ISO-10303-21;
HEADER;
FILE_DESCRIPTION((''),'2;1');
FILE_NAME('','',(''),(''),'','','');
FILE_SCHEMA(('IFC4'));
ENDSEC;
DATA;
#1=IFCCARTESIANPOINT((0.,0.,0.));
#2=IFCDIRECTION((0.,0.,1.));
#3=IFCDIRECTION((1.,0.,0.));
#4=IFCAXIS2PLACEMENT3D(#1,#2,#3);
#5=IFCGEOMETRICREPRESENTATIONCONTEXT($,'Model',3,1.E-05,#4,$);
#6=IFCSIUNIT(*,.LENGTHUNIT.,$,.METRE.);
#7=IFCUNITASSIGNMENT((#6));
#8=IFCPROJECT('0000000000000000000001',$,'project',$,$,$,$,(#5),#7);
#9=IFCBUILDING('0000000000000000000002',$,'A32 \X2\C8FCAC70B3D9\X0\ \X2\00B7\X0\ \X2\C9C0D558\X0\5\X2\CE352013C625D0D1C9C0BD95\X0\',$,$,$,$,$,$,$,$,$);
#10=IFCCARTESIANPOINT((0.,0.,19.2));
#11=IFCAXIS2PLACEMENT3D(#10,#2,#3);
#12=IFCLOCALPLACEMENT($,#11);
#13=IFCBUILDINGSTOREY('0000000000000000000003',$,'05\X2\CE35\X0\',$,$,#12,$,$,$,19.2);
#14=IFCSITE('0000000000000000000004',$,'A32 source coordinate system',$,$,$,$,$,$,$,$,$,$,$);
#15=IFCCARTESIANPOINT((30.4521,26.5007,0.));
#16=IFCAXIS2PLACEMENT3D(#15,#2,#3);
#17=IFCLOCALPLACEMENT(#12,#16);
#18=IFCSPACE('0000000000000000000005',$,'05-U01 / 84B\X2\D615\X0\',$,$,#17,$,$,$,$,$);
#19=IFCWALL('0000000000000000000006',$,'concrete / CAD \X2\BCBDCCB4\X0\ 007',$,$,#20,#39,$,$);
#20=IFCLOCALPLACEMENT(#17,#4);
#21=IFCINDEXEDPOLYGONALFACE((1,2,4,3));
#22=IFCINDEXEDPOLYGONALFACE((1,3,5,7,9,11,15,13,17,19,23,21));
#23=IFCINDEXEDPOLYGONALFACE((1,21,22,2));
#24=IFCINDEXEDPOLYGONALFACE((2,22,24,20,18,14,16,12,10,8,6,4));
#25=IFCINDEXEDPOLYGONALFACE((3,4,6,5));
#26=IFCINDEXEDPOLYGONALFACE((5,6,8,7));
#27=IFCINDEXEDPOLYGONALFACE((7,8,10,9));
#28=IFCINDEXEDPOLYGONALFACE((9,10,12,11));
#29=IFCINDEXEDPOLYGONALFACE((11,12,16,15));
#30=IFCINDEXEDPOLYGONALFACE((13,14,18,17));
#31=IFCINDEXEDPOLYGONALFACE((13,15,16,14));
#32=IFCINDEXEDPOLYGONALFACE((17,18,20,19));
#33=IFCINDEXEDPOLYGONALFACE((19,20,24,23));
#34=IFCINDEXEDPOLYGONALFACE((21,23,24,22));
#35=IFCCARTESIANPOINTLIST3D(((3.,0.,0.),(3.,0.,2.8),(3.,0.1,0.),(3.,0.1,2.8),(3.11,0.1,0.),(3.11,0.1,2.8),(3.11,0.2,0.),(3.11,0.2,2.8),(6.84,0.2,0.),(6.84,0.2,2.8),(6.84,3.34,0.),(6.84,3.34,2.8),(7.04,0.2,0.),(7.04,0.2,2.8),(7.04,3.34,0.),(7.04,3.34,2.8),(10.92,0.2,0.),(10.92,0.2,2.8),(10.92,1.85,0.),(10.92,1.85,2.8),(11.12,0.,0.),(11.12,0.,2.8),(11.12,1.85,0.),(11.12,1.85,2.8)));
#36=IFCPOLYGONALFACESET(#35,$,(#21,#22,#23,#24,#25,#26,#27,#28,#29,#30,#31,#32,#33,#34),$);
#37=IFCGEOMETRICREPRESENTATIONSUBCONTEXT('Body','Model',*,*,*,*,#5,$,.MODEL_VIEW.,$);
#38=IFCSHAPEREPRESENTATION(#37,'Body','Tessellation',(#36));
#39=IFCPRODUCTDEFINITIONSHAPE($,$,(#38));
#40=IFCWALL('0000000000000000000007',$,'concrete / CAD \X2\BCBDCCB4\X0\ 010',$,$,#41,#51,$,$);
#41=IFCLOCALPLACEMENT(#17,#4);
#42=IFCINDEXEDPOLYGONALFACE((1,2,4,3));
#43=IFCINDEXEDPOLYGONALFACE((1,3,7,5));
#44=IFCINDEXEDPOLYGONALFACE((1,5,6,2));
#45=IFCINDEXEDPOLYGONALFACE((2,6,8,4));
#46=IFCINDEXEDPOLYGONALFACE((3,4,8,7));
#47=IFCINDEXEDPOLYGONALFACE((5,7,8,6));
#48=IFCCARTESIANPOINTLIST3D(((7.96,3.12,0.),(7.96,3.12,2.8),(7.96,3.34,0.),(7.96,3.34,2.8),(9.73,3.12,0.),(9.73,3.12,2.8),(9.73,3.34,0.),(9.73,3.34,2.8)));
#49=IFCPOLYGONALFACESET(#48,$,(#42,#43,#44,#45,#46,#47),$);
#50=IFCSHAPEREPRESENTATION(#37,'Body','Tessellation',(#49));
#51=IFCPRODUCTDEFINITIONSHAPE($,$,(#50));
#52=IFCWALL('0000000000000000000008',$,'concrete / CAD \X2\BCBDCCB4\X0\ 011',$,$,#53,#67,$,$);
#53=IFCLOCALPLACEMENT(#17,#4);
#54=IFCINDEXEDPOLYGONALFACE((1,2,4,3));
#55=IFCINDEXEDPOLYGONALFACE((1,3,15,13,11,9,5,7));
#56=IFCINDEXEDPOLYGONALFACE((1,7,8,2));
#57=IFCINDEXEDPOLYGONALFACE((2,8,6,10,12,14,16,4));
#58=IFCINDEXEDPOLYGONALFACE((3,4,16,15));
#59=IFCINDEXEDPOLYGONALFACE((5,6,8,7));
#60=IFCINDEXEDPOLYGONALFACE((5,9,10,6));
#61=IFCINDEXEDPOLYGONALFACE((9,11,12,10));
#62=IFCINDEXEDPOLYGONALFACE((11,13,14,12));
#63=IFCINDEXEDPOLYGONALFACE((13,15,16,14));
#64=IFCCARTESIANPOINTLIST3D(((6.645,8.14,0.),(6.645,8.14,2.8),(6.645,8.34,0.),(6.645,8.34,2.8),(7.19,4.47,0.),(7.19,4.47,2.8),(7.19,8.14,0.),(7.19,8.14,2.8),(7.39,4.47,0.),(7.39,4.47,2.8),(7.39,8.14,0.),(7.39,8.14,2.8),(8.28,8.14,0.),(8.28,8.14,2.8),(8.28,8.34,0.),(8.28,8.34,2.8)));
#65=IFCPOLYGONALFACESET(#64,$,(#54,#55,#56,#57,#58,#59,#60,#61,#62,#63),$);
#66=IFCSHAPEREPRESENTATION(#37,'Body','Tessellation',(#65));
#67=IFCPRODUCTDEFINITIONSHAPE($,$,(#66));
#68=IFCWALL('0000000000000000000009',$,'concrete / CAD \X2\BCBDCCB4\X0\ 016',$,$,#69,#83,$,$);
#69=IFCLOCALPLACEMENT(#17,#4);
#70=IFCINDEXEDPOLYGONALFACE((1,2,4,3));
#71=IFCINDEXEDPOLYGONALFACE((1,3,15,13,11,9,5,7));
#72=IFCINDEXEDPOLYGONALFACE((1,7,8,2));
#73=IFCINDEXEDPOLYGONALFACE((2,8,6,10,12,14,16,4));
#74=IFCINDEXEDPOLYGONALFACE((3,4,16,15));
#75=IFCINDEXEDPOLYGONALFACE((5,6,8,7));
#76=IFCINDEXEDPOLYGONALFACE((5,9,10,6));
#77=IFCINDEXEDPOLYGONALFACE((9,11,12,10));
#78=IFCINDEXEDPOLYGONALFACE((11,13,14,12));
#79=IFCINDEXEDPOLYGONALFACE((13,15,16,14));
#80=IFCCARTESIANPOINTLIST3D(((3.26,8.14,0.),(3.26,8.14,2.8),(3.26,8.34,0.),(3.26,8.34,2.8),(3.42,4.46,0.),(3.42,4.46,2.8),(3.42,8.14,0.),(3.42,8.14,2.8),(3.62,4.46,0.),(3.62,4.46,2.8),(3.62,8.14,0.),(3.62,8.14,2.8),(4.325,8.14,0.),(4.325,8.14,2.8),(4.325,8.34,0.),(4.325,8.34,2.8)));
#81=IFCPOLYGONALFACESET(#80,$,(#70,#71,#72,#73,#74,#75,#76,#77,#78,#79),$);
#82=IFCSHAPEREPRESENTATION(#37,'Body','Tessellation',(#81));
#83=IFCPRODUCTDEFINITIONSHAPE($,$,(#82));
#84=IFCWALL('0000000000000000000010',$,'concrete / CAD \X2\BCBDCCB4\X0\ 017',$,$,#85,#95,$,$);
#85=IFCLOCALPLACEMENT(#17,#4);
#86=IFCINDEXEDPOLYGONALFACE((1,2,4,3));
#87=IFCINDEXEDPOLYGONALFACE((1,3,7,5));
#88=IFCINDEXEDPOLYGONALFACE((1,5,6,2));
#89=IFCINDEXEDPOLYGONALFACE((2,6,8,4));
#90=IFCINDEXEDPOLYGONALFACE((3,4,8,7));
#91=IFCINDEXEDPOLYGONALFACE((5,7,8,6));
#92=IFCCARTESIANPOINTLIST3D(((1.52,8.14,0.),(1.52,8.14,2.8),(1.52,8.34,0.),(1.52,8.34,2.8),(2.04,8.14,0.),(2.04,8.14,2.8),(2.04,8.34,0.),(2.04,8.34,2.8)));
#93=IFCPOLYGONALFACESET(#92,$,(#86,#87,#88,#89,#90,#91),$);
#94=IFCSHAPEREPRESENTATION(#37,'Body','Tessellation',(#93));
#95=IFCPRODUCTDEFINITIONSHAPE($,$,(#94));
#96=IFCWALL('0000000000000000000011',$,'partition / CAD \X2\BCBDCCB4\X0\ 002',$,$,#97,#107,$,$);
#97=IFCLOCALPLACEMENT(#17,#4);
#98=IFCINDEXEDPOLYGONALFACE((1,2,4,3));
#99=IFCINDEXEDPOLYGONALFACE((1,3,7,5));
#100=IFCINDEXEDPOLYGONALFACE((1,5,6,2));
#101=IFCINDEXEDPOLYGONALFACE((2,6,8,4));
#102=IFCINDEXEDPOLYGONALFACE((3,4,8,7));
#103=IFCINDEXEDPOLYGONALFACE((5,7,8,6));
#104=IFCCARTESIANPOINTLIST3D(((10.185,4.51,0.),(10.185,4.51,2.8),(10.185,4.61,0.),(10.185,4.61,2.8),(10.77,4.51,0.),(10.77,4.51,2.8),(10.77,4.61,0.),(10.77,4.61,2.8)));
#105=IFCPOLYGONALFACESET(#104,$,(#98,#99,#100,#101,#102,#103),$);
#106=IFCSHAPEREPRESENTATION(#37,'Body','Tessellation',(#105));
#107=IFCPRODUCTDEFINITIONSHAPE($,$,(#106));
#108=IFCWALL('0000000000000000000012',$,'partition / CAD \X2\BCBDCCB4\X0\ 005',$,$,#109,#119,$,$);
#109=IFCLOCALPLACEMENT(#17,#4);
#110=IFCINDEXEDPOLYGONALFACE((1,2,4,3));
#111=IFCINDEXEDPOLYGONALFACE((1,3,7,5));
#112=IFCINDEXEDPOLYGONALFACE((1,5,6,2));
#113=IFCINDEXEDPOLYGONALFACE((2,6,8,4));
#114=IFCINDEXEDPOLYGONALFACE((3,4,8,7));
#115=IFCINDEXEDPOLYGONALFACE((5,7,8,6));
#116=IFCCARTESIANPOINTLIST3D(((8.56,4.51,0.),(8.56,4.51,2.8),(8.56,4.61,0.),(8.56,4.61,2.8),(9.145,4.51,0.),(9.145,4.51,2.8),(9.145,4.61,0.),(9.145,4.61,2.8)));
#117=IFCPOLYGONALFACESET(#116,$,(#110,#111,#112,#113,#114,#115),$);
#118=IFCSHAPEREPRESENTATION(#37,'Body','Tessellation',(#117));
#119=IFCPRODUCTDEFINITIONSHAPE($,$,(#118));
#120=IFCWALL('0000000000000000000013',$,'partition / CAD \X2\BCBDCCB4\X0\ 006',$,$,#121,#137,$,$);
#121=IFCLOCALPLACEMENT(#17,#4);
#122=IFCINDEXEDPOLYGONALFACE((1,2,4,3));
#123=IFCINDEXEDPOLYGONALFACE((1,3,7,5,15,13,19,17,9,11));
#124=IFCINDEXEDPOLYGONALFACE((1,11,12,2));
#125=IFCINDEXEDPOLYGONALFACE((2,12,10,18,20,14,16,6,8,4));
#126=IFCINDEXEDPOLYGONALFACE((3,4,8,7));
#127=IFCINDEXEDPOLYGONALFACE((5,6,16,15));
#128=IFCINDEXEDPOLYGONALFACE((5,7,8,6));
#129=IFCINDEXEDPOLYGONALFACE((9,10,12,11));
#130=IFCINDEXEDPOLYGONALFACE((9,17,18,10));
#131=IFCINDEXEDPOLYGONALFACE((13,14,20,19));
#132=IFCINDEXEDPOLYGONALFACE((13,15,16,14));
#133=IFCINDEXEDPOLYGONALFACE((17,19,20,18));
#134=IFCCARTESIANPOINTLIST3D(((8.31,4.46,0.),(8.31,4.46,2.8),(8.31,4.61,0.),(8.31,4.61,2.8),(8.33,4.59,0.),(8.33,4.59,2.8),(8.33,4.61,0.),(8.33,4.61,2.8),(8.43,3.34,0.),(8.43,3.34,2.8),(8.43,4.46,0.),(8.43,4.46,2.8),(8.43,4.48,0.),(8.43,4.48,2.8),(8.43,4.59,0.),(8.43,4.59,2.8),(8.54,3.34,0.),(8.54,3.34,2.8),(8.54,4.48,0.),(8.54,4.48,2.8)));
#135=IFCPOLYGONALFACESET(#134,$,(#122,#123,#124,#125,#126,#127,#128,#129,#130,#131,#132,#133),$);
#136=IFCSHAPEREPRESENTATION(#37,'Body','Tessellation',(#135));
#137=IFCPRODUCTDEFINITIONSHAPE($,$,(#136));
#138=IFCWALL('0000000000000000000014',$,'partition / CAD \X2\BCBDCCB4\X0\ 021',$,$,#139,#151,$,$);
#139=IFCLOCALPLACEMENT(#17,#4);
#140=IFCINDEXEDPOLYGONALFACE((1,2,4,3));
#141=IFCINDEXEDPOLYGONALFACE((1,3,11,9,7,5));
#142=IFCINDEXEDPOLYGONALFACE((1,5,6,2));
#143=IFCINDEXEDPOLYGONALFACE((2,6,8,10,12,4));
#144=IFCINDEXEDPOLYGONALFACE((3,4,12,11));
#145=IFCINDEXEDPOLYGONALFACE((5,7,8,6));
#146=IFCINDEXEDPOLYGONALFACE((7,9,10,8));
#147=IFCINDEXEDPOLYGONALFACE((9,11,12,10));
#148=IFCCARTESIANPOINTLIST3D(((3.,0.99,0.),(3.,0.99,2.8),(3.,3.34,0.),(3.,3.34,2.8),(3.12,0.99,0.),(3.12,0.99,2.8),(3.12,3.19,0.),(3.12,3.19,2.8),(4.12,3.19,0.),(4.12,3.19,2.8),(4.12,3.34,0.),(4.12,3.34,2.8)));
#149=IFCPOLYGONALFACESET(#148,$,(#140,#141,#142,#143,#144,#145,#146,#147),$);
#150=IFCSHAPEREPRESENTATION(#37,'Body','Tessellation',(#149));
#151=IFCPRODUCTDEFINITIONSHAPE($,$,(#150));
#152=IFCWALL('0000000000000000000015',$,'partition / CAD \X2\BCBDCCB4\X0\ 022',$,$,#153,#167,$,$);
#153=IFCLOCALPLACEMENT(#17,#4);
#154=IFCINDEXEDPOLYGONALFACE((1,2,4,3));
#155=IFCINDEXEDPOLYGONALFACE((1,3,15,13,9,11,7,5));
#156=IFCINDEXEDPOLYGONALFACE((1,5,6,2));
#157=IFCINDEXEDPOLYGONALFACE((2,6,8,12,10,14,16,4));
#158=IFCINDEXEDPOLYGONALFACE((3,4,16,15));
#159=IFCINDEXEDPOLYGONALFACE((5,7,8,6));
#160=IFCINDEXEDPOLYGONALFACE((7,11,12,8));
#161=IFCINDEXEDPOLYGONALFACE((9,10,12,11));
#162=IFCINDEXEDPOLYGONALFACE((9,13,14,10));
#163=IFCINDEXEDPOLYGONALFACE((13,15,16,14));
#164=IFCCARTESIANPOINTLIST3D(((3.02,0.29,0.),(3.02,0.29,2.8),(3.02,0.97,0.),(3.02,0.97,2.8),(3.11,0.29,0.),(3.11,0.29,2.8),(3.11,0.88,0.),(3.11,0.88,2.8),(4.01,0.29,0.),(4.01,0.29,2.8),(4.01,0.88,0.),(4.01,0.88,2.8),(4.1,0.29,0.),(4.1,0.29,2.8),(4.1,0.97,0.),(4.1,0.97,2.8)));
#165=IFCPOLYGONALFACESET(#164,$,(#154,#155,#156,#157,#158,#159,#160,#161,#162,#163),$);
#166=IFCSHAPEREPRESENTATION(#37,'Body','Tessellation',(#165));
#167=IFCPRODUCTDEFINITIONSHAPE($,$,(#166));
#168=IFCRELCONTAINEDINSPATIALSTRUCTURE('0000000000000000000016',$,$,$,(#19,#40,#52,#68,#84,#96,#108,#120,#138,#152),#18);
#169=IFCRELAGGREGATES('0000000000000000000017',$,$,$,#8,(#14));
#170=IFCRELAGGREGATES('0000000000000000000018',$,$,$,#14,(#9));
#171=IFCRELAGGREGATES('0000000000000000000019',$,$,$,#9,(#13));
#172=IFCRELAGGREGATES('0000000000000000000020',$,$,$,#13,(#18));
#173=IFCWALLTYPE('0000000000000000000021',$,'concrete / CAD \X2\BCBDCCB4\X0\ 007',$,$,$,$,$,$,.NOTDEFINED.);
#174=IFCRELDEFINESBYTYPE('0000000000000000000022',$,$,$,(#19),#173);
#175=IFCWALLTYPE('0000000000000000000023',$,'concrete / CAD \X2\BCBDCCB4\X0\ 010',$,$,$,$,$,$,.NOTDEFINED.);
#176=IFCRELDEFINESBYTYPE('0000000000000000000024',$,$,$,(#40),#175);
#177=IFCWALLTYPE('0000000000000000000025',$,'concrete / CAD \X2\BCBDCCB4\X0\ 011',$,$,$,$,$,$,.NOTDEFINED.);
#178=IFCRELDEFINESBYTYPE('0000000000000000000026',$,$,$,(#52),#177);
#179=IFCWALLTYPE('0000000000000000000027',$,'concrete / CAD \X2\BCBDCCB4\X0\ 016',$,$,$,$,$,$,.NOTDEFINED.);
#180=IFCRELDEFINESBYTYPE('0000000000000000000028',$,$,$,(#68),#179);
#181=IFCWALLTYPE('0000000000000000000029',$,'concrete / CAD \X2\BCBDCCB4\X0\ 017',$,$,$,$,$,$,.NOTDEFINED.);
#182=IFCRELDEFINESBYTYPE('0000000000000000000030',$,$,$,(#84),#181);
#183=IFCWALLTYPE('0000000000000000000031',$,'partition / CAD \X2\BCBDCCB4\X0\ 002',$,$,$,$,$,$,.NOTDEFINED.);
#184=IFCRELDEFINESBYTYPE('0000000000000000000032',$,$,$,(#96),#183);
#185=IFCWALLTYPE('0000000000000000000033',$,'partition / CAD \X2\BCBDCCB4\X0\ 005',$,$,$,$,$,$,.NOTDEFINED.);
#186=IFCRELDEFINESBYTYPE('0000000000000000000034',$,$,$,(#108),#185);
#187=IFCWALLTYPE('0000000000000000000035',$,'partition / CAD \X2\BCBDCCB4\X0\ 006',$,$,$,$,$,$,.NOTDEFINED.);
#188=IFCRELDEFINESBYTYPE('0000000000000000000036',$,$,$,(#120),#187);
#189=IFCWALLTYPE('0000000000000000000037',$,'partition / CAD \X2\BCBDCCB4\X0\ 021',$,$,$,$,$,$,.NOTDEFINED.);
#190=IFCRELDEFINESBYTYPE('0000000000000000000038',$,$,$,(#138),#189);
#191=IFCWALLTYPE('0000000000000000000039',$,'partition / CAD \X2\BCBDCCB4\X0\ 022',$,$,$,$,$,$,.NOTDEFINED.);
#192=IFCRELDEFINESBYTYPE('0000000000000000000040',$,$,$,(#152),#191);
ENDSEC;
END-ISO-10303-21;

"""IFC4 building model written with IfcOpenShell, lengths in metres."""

from ifc_helpers import new_model, si_unit, frame, origin, origin_with_axes, place, context, subcontext, project, spatial, polyline, outline, extrude, source, transform, mapped, type_object, type_shapes, element, save


model = new_model("IFC4")

# Units and contexts
model_context = context("Model", 3, precision=1e-05, world=origin_with_axes())
body_context = subcontext(model_context, "Body", "Model", "MODEL_VIEW")
ifc_project = project(units=[si_unit("LENGTHUNIT", "METRE")], contexts=[model_context])

# Site, building, storey, space
site = spatial("IfcSite", under=ifc_project, Name="A32 source coordinate system")
building = spatial("IfcBuilding", under=site, Name="A32 주거동 · 지하5층–옥탑지붕")
storey_placement = place(None, frame((0.0, 0.0, 19.2), z_axis=(0.0, 0.0, 1.0), x_axis=(1.0, 0.0, 0.0)))
storey = spatial("IfcBuildingStorey", under=building, at=storey_placement, Name="05층", Elevation=19.2)
space_1_placement = place(storey_placement, frame((30.4521, 26.5007, 0.0), z_axis=(0.0, 0.0, 1.0), x_axis=(1.0, 0.0, 0.0)))
space_1 = spatial("IfcSpace", under=storey, at=space_1_placement, Name="05-U01 / 84B형")

# Walls
wall_type_1 = type_object("IfcWallType", Name="concrete / CAD 벽체 007", PredefinedType="NOTDEFINED")
shared_shape_1 = source(origin(), body_context, "Body", "SweptSolid", [
    extrude(outline(polyline([(3.0, 0.0), (3.0, 0.1), (3.11, 0.1), (3.11, 0.2), (6.84, 0.2), (6.84, 3.34), (7.04, 3.34), (7.04, 0.2), (10.92, 0.2), (10.92, 1.85), (11.12, 1.85), (11.12, 0.0), (3.0, 0.0)])), origin(), (0.0, 0.0, 1.0), 2.8),
])
type_shapes(wall_type_1, [shared_shape_1])
wall_1_placement = place(space_1_placement, origin_with_axes())
element("IfcWall", 1, at=wall_1_placement, inside=space_1, type_object=wall_type_1, Name="concrete / CAD 벽체 007", context=body_context, shape_type="MappedRepresentation", body=[
    mapped(shared_shape_1, transform((0.0, 0.0, 0.0), scale=1.0)),
])
wall_type_2 = type_object("IfcWallType", Name="concrete / CAD 벽체 010", PredefinedType="NOTDEFINED")
shared_shape_2 = source(origin(), body_context, "Body", "SweptSolid", [
    extrude(outline(polyline([(7.96, 3.12), (7.96, 3.34), (9.73, 3.34), (9.73, 3.12), (7.96, 3.12)])), origin(), (0.0, 0.0, 1.0), 2.8),
])
type_shapes(wall_type_2, [shared_shape_2])
wall_2_placement = place(space_1_placement, origin_with_axes())
element("IfcWall", 2, at=wall_2_placement, inside=space_1, type_object=wall_type_2, Name="concrete / CAD 벽체 010", context=body_context, shape_type="MappedRepresentation", body=[
    mapped(shared_shape_2, transform((0.0, 0.0, 0.0), scale=1.0)),
])
wall_type_3 = type_object("IfcWallType", Name="concrete / CAD 벽체 011", PredefinedType="NOTDEFINED")
shared_shape_3 = source(origin(), body_context, "Body", "SweptSolid", [
    extrude(outline(polyline([(7.19, 8.14), (6.645, 8.14), (6.645, 8.34), (8.28, 8.34), (8.28, 8.14), (7.39, 8.14), (7.39, 4.47), (7.19, 4.47), (7.19, 8.14)])), origin(), (0.0, 0.0, 1.0), 2.8),
])
type_shapes(wall_type_3, [shared_shape_3])
wall_3_placement = place(space_1_placement, origin_with_axes())
element("IfcWall", 3, at=wall_3_placement, inside=space_1, type_object=wall_type_3, Name="concrete / CAD 벽체 011", context=body_context, shape_type="MappedRepresentation", body=[
    mapped(shared_shape_3, transform((0.0, 0.0, 0.0), scale=1.0)),
])
wall_type_4 = type_object("IfcWallType", Name="concrete / CAD 벽체 016", PredefinedType="NOTDEFINED")
shared_shape_4 = source(origin(), body_context, "Body", "SweptSolid", [
    extrude(outline(polyline([(3.26, 8.14), (3.26, 8.34), (4.325, 8.34), (4.325, 8.14), (3.62, 8.14), (3.62, 4.46), (3.42, 4.46), (3.42, 8.14), (3.26, 8.14)])), origin(), (0.0, 0.0, 1.0), 2.8),
])
type_shapes(wall_type_4, [shared_shape_4])
wall_4_placement = place(space_1_placement, origin_with_axes())
element("IfcWall", 4, at=wall_4_placement, inside=space_1, type_object=wall_type_4, Name="concrete / CAD 벽체 016", context=body_context, shape_type="MappedRepresentation", body=[
    mapped(shared_shape_4, transform((0.0, 0.0, 0.0), scale=1.0)),
])
wall_type_5 = type_object("IfcWallType", Name="concrete / CAD 벽체 017", PredefinedType="NOTDEFINED")
shared_shape_5 = source(origin(), body_context, "Body", "SweptSolid", [
    extrude(outline(polyline([(1.52, 8.34), (2.04, 8.34), (2.04, 8.14), (1.52, 8.14), (1.52, 8.34)])), origin(), (0.0, 0.0, 1.0), 2.8),
])
type_shapes(wall_type_5, [shared_shape_5])
wall_5_placement = place(space_1_placement, origin_with_axes())
element("IfcWall", 5, at=wall_5_placement, inside=space_1, type_object=wall_type_5, Name="concrete / CAD 벽체 017", context=body_context, shape_type="MappedRepresentation", body=[
    mapped(shared_shape_5, transform((0.0, 0.0, 0.0), scale=1.0)),
])
wall_type_6 = type_object("IfcWallType", Name="partition / CAD 벽체 002", PredefinedType="NOTDEFINED")
shared_shape_6 = source(origin(), body_context, "Body", "SweptSolid", [
    extrude(outline(polyline([(10.185, 4.51), (10.185, 4.61), (10.77, 4.61), (10.77, 4.51), (10.185, 4.51)])), origin(), (0.0, 0.0, 1.0), 2.8),
])
type_shapes(wall_type_6, [shared_shape_6])
wall_6_placement = place(space_1_placement, origin_with_axes())
element("IfcWall", 6, at=wall_6_placement, inside=space_1, type_object=wall_type_6, Name="partition / CAD 벽체 002", context=body_context, shape_type="MappedRepresentation", body=[
    mapped(shared_shape_6, transform((0.0, 0.0, 0.0), scale=1.0)),
])
wall_type_7 = type_object("IfcWallType", Name="partition / CAD 벽체 005", PredefinedType="NOTDEFINED")
shared_shape_7 = source(origin(), body_context, "Body", "SweptSolid", [
    extrude(outline(polyline([(8.56, 4.51), (8.56, 4.61), (9.145, 4.61), (9.145, 4.51), (8.56, 4.51)])), origin(), (0.0, 0.0, 1.0), 2.8),
])
type_shapes(wall_type_7, [shared_shape_7])
wall_7_placement = place(space_1_placement, origin_with_axes())
element("IfcWall", 7, at=wall_7_placement, inside=space_1, type_object=wall_type_7, Name="partition / CAD 벽체 005", context=body_context, shape_type="MappedRepresentation", body=[
    mapped(shared_shape_7, transform((0.0, 0.0, 0.0), scale=1.0)),
])
wall_type_8 = type_object("IfcWallType", Name="partition / CAD 벽체 006", PredefinedType="NOTDEFINED")
shared_shape_8 = source(origin(), body_context, "Body", "SweptSolid", [
    extrude(outline(polyline([(8.43, 4.46), (8.31, 4.46), (8.31, 4.61), (8.33, 4.61), (8.33, 4.59), (8.43, 4.59), (8.43, 4.48), (8.54, 4.48), (8.54, 3.34), (8.43, 3.34), (8.43, 4.46)])), origin(), (0.0, 0.0, 1.0), 2.8),
])
type_shapes(wall_type_8, [shared_shape_8])
wall_8_placement = place(space_1_placement, origin_with_axes())
element("IfcWall", 8, at=wall_8_placement, inside=space_1, type_object=wall_type_8, Name="partition / CAD 벽체 006", context=body_context, shape_type="MappedRepresentation", body=[
    mapped(shared_shape_8, transform((0.0, 0.0, 0.0), scale=1.0)),
])
wall_type_9 = type_object("IfcWallType", Name="partition / CAD 벽체 021", PredefinedType="NOTDEFINED")
shared_shape_9 = source(origin(), body_context, "Body", "SweptSolid", [
    extrude(outline(polyline([(4.12, 3.34), (4.12, 3.19), (3.12, 3.19), (3.12, 0.99), (3.0, 0.99), (3.0, 3.34), (4.12, 3.34)])), origin(), (0.0, 0.0, 1.0), 2.8),
])
type_shapes(wall_type_9, [shared_shape_9])
wall_9_placement = place(space_1_placement, origin_with_axes())
element("IfcWall", 9, at=wall_9_placement, inside=space_1, type_object=wall_type_9, Name="partition / CAD 벽체 021", context=body_context, shape_type="MappedRepresentation", body=[
    mapped(shared_shape_9, transform((0.0, 0.0, 0.0), scale=1.0)),
])
wall_type_10 = type_object("IfcWallType", Name="partition / CAD 벽체 022", PredefinedType="NOTDEFINED")
shared_shape_10 = source(origin(), body_context, "Body", "SweptSolid", [
    extrude(outline(polyline([(4.1, 0.97), (4.1, 0.29), (4.01, 0.29), (4.01, 0.88), (3.11, 0.88), (3.11, 0.29), (3.02, 0.29), (3.02, 0.97), (4.1, 0.97)])), origin(), (0.0, 0.0, 1.0), 2.8),
])
type_shapes(wall_type_10, [shared_shape_10])
wall_10_placement = place(space_1_placement, origin_with_axes())
element("IfcWall", 10, at=wall_10_placement, inside=space_1, type_object=wall_type_10, Name="partition / CAD 벽체 022", context=body_context, shape_type="MappedRepresentation", body=[
    mapped(shared_shape_10, transform((0.0, 0.0, 0.0), scale=1.0)),
])

save(model, "model.ifc")
